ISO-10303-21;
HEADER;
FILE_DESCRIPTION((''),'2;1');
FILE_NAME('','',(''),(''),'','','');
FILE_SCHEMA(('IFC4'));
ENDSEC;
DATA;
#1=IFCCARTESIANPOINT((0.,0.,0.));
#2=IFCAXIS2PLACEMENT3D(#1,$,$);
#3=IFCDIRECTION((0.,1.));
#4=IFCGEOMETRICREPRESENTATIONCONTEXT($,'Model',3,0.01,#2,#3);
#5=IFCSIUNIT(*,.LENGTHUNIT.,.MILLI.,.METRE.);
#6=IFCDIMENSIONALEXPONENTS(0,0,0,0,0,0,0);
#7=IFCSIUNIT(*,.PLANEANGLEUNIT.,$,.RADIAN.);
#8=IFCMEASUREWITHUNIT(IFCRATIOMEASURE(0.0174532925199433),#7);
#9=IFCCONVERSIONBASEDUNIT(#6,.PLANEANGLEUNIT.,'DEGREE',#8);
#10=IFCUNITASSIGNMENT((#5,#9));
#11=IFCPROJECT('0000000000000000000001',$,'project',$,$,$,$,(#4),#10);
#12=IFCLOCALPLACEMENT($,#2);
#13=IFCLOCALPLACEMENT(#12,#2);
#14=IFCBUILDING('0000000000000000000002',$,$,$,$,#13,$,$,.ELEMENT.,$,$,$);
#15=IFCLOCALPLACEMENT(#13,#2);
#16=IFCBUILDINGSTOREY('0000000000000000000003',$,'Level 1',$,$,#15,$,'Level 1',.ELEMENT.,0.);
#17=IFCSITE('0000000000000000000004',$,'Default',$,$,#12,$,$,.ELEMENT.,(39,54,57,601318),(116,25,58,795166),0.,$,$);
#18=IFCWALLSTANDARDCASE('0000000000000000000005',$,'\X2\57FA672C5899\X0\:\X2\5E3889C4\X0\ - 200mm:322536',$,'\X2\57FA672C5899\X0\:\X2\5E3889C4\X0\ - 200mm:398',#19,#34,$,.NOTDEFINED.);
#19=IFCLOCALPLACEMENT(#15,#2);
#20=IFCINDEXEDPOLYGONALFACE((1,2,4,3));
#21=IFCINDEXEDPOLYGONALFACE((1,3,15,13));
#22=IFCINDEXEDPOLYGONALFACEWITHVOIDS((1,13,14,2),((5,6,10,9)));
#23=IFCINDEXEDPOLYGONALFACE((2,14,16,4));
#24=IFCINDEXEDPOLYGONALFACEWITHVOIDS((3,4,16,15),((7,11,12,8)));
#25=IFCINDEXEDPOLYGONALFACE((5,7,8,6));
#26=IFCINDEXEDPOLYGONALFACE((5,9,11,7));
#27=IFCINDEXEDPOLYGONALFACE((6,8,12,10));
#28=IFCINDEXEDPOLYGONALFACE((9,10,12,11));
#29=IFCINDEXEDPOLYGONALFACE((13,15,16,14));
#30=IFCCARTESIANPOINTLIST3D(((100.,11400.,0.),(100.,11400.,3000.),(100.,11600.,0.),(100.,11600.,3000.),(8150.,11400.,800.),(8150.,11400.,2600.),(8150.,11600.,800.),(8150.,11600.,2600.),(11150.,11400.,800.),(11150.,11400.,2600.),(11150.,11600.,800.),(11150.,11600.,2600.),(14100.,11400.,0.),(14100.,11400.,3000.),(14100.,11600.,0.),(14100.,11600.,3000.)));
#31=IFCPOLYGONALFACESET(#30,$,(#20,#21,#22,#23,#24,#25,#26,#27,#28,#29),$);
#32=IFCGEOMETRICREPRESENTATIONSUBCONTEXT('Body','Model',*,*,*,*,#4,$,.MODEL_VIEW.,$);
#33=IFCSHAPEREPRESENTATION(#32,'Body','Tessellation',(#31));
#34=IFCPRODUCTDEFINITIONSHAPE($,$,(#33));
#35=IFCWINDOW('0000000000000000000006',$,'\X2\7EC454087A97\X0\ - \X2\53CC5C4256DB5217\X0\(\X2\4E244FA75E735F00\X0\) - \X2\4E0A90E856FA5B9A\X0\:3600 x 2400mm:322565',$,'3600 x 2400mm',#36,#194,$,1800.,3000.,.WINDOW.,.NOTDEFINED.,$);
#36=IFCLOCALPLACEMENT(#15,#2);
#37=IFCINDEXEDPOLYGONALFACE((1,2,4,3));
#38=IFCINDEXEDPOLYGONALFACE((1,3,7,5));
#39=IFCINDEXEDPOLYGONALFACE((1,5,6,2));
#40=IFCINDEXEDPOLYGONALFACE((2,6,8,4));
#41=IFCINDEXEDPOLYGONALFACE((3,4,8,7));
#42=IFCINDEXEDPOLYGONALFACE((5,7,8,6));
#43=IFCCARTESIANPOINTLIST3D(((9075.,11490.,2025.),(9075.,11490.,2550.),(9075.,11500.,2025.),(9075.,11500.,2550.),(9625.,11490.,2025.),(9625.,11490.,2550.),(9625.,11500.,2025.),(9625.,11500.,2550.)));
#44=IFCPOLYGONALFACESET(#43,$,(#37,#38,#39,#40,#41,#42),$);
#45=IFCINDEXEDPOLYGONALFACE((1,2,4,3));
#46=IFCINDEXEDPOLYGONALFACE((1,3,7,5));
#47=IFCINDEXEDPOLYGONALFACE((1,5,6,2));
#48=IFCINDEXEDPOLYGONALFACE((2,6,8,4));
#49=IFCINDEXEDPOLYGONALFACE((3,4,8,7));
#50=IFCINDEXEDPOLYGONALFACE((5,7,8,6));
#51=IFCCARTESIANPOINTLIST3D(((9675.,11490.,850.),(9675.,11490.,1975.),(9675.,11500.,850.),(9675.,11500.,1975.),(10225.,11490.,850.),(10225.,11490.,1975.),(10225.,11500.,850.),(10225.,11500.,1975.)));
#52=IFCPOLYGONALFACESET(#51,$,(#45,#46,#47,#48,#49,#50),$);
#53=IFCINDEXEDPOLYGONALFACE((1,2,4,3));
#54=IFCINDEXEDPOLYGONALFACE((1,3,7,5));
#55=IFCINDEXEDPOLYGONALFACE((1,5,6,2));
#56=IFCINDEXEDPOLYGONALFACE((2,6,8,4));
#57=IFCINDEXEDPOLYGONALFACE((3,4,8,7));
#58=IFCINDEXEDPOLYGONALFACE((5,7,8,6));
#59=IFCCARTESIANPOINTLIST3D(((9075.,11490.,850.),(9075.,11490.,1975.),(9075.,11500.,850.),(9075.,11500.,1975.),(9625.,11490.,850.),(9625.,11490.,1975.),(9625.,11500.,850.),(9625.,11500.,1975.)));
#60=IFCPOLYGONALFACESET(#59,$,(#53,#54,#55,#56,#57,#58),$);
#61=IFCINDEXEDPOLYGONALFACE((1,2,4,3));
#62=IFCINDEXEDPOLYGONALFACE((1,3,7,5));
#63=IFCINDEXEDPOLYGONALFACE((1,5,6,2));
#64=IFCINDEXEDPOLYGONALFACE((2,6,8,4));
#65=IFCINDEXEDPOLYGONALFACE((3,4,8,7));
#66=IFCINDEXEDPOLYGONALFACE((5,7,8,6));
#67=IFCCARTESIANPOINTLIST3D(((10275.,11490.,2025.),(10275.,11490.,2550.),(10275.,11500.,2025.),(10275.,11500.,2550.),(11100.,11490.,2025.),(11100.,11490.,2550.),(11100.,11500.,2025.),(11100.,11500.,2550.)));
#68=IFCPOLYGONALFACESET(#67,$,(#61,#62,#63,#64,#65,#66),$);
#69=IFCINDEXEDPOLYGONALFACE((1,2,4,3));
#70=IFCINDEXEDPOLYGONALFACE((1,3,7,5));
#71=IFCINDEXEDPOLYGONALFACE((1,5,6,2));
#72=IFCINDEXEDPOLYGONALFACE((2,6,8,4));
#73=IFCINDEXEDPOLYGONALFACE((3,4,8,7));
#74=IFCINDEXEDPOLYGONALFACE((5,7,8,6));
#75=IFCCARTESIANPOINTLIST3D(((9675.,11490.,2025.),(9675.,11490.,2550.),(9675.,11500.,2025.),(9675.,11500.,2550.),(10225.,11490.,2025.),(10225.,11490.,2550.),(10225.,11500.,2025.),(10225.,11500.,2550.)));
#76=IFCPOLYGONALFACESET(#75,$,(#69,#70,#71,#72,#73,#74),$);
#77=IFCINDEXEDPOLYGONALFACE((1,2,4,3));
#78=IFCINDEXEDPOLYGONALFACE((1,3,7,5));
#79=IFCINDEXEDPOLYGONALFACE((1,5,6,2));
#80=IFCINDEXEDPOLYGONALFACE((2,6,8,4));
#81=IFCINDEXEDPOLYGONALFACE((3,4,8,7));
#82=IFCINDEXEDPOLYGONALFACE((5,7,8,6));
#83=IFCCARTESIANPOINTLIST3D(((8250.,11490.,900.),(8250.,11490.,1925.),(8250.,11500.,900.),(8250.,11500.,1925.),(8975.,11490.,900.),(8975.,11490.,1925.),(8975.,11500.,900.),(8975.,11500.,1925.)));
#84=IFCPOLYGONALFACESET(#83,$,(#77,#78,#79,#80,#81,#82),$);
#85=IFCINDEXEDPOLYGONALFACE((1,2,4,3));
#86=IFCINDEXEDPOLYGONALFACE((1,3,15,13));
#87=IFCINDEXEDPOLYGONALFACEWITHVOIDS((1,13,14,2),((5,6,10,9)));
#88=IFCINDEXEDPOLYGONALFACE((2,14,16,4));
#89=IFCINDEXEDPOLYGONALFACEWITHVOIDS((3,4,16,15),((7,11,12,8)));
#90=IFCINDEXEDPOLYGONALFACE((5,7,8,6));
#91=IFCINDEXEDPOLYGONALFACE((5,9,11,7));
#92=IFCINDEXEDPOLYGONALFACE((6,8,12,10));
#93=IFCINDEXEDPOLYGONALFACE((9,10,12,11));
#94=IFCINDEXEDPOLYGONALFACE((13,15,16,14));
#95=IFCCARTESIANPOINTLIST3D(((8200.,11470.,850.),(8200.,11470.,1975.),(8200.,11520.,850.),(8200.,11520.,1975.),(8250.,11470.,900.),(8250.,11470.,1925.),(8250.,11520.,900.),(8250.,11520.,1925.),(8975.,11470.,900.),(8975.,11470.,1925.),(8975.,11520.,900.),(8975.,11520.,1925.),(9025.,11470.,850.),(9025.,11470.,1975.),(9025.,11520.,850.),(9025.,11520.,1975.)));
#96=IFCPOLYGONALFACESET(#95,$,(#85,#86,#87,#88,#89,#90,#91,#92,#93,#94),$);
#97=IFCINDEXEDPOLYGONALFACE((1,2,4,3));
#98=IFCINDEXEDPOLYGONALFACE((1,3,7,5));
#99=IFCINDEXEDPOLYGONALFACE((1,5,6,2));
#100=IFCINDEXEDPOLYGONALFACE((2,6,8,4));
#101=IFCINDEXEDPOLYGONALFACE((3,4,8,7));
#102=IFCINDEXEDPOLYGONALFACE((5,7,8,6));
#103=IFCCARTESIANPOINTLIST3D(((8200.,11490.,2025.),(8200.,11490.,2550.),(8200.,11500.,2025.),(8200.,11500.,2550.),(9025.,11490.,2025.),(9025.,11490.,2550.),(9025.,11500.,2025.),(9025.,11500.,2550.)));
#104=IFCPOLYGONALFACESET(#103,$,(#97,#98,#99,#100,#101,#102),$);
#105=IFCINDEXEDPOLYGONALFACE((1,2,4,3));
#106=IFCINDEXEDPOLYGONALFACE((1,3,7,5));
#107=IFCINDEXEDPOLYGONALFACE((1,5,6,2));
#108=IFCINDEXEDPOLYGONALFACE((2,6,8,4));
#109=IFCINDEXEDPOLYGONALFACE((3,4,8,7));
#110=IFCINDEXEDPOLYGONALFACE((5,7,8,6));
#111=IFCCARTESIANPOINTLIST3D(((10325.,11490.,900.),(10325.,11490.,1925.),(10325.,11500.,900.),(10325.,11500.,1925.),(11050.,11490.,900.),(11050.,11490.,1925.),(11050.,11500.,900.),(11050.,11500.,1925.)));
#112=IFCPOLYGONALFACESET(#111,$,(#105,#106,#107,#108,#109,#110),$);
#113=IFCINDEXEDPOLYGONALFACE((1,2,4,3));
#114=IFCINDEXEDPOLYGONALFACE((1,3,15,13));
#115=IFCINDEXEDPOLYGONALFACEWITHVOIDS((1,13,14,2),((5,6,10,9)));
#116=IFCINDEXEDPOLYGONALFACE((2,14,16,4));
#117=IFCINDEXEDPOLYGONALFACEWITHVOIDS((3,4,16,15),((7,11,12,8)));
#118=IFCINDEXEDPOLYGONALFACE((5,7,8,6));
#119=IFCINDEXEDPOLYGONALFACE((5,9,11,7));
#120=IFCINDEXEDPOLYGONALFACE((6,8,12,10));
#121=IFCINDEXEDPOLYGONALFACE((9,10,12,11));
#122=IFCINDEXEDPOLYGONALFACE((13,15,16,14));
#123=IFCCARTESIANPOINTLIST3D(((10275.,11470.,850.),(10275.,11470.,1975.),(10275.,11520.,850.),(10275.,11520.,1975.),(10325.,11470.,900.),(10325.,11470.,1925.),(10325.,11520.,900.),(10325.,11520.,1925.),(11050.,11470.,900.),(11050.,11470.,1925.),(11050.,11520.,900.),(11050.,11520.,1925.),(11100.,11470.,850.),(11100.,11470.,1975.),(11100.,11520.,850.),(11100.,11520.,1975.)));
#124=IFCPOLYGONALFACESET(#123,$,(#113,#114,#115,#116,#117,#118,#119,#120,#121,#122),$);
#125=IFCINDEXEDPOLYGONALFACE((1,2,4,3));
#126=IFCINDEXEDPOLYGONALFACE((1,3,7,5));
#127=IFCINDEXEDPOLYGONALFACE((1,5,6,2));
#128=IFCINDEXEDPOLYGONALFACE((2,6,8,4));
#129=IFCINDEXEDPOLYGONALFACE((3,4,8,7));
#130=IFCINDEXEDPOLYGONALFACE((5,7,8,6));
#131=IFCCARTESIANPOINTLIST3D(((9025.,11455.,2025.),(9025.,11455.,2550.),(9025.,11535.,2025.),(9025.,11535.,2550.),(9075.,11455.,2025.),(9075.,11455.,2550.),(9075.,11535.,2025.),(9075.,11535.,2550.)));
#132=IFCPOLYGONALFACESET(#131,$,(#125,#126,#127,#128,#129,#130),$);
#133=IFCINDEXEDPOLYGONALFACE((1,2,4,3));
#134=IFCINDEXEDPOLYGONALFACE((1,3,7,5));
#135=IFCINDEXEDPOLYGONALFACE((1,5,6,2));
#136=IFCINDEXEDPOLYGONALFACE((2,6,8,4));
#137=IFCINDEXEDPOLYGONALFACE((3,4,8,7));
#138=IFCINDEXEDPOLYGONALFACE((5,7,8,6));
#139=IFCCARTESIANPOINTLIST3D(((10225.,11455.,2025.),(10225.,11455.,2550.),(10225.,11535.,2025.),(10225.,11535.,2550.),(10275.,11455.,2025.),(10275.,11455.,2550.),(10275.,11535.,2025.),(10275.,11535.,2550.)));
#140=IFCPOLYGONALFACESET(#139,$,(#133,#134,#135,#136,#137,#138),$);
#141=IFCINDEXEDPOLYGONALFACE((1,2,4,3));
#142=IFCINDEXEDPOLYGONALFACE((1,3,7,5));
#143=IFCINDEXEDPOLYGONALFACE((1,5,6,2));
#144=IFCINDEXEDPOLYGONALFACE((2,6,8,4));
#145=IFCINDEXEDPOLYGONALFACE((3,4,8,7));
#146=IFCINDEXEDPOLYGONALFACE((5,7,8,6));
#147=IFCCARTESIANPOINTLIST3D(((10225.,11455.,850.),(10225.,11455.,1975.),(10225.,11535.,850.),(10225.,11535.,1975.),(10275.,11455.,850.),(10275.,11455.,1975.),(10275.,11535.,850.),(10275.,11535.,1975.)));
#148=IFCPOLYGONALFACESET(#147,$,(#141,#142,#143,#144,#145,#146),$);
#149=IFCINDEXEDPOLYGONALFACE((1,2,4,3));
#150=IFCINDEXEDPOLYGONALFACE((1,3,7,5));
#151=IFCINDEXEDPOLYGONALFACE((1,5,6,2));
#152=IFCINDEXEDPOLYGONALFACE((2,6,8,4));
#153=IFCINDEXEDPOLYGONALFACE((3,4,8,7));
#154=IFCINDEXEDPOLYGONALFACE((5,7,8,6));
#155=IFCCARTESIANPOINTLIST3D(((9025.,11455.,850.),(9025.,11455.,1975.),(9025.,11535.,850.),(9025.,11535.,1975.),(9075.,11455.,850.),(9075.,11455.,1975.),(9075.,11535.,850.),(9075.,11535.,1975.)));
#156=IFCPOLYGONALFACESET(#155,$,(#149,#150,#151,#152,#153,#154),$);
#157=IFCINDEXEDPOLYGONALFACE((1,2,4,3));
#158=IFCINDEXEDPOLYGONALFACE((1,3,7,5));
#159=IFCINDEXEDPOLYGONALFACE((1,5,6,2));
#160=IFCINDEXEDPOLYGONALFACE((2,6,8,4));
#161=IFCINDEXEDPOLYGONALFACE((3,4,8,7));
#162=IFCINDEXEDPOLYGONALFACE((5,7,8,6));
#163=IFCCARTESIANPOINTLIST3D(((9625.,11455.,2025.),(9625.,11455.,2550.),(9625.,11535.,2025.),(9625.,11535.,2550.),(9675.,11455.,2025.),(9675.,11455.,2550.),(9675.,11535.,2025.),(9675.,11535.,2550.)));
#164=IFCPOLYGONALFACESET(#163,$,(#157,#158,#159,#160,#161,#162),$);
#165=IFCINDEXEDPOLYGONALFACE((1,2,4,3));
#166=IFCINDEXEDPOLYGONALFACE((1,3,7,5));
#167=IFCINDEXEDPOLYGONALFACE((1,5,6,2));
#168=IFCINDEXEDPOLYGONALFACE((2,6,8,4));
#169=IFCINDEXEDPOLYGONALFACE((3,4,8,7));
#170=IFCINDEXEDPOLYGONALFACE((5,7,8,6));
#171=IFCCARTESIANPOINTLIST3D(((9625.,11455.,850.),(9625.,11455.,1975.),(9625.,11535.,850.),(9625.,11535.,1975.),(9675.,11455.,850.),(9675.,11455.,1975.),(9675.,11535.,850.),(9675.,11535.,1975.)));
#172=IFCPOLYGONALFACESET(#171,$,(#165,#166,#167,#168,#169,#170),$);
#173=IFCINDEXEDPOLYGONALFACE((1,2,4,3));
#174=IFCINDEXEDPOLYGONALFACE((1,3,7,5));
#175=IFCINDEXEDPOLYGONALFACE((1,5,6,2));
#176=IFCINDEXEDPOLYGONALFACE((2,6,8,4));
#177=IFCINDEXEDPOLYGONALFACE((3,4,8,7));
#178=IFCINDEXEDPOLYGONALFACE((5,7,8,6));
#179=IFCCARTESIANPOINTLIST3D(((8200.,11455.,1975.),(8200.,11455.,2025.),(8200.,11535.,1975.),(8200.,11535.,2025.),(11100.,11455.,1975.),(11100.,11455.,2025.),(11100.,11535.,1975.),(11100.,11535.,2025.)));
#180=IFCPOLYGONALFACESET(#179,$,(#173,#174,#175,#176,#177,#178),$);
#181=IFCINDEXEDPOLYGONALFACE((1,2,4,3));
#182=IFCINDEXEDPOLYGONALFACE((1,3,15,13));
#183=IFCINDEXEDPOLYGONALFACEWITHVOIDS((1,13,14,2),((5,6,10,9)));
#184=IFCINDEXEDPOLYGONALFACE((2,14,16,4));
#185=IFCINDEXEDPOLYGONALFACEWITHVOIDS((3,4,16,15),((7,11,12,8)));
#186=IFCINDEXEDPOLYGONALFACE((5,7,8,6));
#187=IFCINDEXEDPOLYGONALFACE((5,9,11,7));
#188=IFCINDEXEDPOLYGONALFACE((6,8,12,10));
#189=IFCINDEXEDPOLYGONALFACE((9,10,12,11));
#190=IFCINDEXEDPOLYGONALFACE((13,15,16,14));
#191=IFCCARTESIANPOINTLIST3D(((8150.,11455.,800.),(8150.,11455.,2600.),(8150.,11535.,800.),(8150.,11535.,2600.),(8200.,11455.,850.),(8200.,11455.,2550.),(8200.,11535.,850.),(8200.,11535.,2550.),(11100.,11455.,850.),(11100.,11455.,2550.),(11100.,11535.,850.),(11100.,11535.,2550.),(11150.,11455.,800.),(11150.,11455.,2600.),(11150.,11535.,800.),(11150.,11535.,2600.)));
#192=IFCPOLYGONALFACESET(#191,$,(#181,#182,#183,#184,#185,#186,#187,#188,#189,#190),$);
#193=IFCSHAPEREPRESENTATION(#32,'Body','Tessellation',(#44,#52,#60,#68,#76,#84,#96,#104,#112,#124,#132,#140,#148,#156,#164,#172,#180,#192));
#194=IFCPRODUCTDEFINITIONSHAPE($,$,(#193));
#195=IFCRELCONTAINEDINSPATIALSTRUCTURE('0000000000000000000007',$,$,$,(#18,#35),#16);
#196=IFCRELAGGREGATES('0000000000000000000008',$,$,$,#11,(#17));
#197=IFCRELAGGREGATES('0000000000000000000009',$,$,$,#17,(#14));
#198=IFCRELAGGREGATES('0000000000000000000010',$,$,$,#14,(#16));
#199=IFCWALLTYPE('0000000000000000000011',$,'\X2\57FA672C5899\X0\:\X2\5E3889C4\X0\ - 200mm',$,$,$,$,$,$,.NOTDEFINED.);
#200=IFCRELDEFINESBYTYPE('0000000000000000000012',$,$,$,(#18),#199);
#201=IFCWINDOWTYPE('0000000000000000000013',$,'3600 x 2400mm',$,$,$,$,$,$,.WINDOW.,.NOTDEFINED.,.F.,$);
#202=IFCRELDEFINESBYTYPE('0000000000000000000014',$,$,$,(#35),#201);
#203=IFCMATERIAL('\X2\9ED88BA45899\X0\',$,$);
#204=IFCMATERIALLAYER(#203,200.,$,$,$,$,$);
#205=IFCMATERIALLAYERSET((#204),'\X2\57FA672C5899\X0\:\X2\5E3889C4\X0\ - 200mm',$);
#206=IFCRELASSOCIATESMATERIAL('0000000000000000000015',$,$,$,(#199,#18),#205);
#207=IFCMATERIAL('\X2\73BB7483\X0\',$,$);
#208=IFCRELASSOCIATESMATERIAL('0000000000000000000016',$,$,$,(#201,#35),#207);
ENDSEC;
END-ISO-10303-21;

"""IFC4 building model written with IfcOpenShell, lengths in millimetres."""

from ifc_helpers import new_model, entity, si_unit, converted_unit, direction, frame, frame_2d, origin, origin_2d_with_axis, place, context, subcontext, project, spatial, polyline, rectangle, outline, extrude, source, transform, mapped, material, layer, layer_set, layer_usage, type_object, type_shapes, element, fill, save


model = new_model("IFC4")

# Units and contexts
model_context = context("Model", 3, precision=0.01, world=origin(), true_north=direction((0.0, 1.0)))
body_context = subcontext(model_context, "Body", "Model", "MODEL_VIEW")
ifc_project = project(units=[si_unit("LENGTHUNIT", "METRE", prefix="MILLI"), converted_unit("PLANEANGLEUNIT", "DEGREE", entity("IfcRatioMeasure", 0.0174532925199433), si_unit("PLANEANGLEUNIT", "RADIAN"), dimensions=[0, 0, 0, 0, 0, 0, 0])], contexts=[model_context])

# Site, building, storey
site_placement = place(None, origin())
site = spatial("IfcSite", under=ifc_project, at=site_placement, Name="Default", CompositionType="ELEMENT", RefLatitude=(39, 54, 57, 601318), RefLongitude=(116, 25, 58, 795166), RefElevation=0.0)
building_placement = place(site_placement, origin())
building = spatial("IfcBuilding", under=site, at=building_placement, CompositionType="ELEMENT")
storey_placement = place(building_placement, origin())
storey = spatial("IfcBuildingStorey", under=building, at=storey_placement, Name="Level 1", LongName="Level 1", CompositionType="ELEMENT", Elevation=0.0)

# Shared definitions
ifc_material_1 = material(Name="默认墙")
ifc_layer_1 = layer(ifc_material_1, 200.0)
ifc_layer_set_1 = layer_set([ifc_layer_1], Name="基本墙:常规 - 200mm")
wall_type = type_object("IfcWallType", Name="基本墙:常规 - 200mm", PredefinedType="NOTDEFINED", material=ifc_layer_set_1)
ifc_material_2 = material(Name="玻璃")
window_type_1 = type_object("IfcWindowType", Name="3600 x 2400mm", ParameterTakesPrecedence=False, PartitioningType="NOTDEFINED", PredefinedType="WINDOW", material=ifc_material_2)
shared_shape_1 = source(origin(), body_context, "Body", "SweptSolid", [
    extrude(rectangle(XDim=10.0, YDim=550.0, at=origin_2d_with_axis()), frame((1200.0, 95.0, 1225.0), z_axis=(0.0, 0.0, 1.0), x_axis=(0.0, 1.0, 0.0)), (0.0, 0.0, 1.0), 525.0),
    extrude(rectangle(XDim=10.0, YDim=550.0, at=origin_2d_with_axis()), frame((1800.0, 95.0, 50.0), z_axis=(0.0, 0.0, 1.0), x_axis=(0.0, 1.0, 0.0)), (0.0, 0.0, 1.0), 1125.0),
    extrude(rectangle(XDim=10.0, YDim=550.0, at=origin_2d_with_axis()), frame((1200.0, 95.0, 50.0), z_axis=(0.0, 0.0, 1.0), x_axis=(0.0, 1.0, 0.0)), (0.0, 0.0, 1.0), 1125.0),
    extrude(rectangle(XDim=10.0, YDim=825.0, at=frame_2d((0.0, 0.0), x_axis=(1.0, 0.0))), frame((2537.5, 95.0, 1225.0), z_axis=(0.0, 0.0, 1.0), x_axis=(0.0, 1.0, 0.0)), (0.0, 0.0, 1.0), 525.0),
    extrude(rectangle(XDim=10.0, YDim=550.0, at=frame_2d((0.0, 0.0), x_axis=(1.0, 0.0))), frame((1800.0, 95.0, 1225.0), z_axis=(0.0, 0.0, 1.0), x_axis=(0.0, 1.0, 0.0)), (0.0, 0.0, 1.0), 525.0),
    extrude(rectangle(XDim=10.0, YDim=725.0, at=frame_2d((0.0, 0.0), x_axis=(1.0, 0.0))), frame((462.5, 95.0, 100.0), z_axis=(0.0, 0.0, 1.0), x_axis=(0.0, 1.0, 0.0)), (0.0, 0.0, 1.0), 1025.0),
    extrude(outline(polyline([(-562.5, -412.5), (562.5, -412.5), (562.5, 412.5), (-562.5, 412.5), (-562.5, -412.5)]), holes=[polyline([(512.5, -362.5), (-512.5, -362.5), (-512.5, 362.5), (512.5, 362.5), (512.5, -362.5)])]), frame((462.5, 70.0, 612.5), z_axis=(0.0, 1.0, 0.0), x_axis=(0.0, 0.0, -1.0)), (0.0, 0.0, 1.0), 50.0),
    extrude(rectangle(XDim=10.0, YDim=825.0, at=origin_2d_with_axis()), frame((462.5, 95.0, 1225.0), z_axis=(0.0, 0.0, 1.0), x_axis=(0.0, 1.0, 0.0)), (0.0, 0.0, 1.0), 525.0),
    extrude(rectangle(XDim=10.0, YDim=725.0, at=frame_2d((0.0, 0.0), x_axis=(1.0, 0.0))), frame((2537.5, 95.0, 100.0), z_axis=(0.0, 0.0, 1.0), x_axis=(0.0, 1.0, 0.0)), (0.0, 0.0, 1.0), 1025.0),
    extrude(outline(polyline([(-562.5, -412.5), (562.5, -412.5), (562.5, 412.5), (-562.5, 412.5), (-562.5, -412.5)]), holes=[polyline([(512.5, -362.5), (-512.5, -362.5), (-512.5, 362.5), (512.5, 362.5), (512.5, -362.5)])]), frame((2537.5, 70.0, 612.5), z_axis=(0.0, 1.0, 0.0), x_axis=(0.0, 0.0, -1.0)), (0.0, 0.0, 1.0), 50.0),
    extrude(rectangle(XDim=80.0, YDim=50.0, at=origin_2d_with_axis()), frame((900.0, 95.0, 1225.0), z_axis=(0.0, 0.0, 1.0), x_axis=(0.0, -1.0, 0.0)), (0.0, 0.0, 1.0), 525.0),
    extrude(rectangle(XDim=80.0, YDim=50.0, at=frame_2d((0.0, 0.0), x_axis=(1.0, 0.0))), frame((2100.0, 95.0, 1225.0), z_axis=(0.0, 0.0, 1.0), x_axis=(0.0, -1.0, 0.0)), (0.0, 0.0, 1.0), 525.0),
    extrude(rectangle(XDim=80.0, YDim=50.0, at=origin_2d_with_axis()), frame((2100.0, 95.0, 50.0), z_axis=(0.0, 0.0, 1.0), x_axis=(0.0, -1.0, 0.0)), (0.0, 0.0, 1.0), 1125.0),
    extrude(rectangle(XDim=80.0, YDim=50.0, at=origin_2d_with_axis()), frame((900.0, 95.0, 50.0), z_axis=(0.0, 0.0, 1.0), x_axis=(0.0, -1.0, 0.0)), (0.0, 0.0, 1.0), 1125.0),
    extrude(rectangle(XDim=80.0, YDim=50.0, at=frame_2d((0.0, 0.0), x_axis=(1.0, 0.0))), frame((1500.0, 95.0, 1225.0), z_axis=(0.0, 0.0, 1.0), x_axis=(0.0, -1.0, 0.0)), (0.0, 0.0, 1.0), 525.0),
    extrude(rectangle(XDim=80.0, YDim=50.0, at=origin_2d_with_axis()), frame((1500.0, 95.0, 50.0), z_axis=(0.0, 0.0, 1.0), x_axis=(0.0, -1.0, 0.0)), (0.0, 0.0, 1.0), 1125.0),
    extrude(rectangle(XDim=80.0, YDim=2900.0, at=frame_2d((0.0, 0.0), x_axis=(1.0, 0.0))), frame((1500.0, 95.0, 1175.0), z_axis=(0.0, 0.0, 1.0), x_axis=(0.0, -1.0, 0.0)), (0.0, 0.0, 1.0), 50.0),
    extrude(outline(polyline([(-1500.0, -900.0), (1500.0, -900.0), (1500.0, 900.0), (-1500.0, 900.0), (-1500.0, -900.0)]), holes=[polyline([(1450.0, -850.0), (-1450.0, -850.0), (-1450.0, 850.0), (1450.0, 850.0), (1450.0, -850.0)])]), frame((1500.0, 55.0, 900.0), z_axis=(0.0, 1.0, 0.0), x_axis=(1.0, 0.0, 0.0)), (0.0, 0.0, 1.0), 80.0),
])
type_shapes(window_type_1, [shared_shape_1])

# Wall, opening, window
ifc_layer_usage_1 = layer_usage(ifc_layer_set_1, "AXIS2", "NEGATIVE", 100.0)
wall_1_placement = place(storey_placement, frame((100.0, 11500.0, 0.0)))
wall_1 = element("IfcWallStandardCase", 1, at=wall_1_placement, inside=storey, type_object=wall_type, material=ifc_layer_usage_1, Name="基本墙:常规 - 200mm:322536", ObjectType="基本墙:常规 - 200mm:398", PredefinedType="NOTDEFINED", context=body_context, shape_type="SweptSolid", body=[
    extrude(rectangle(XDim=14000.0, YDim=200.0, at=frame_2d((7000.0, 0.0), x_axis=(-1.0, 0.0))), origin(), (0.0, 0.0, 1.0), 3000.0),
])
opening_1_placement = place(wall_1_placement, frame((8050.0, -100.0, 800.0)))
opening_1 = element("IfcOpeningElement", 2, at=opening_1_placement, cuts=wall_1, ObjectType="Opening", PredefinedType="OPENING", context=body_context, shape_type="SweptSolid", body=[
    extrude(rectangle(XDim=1800.0, YDim=3000.0, at=frame_2d((900.0, 1500.0), x_axis=(1.0, 0.0))), frame((0.0, 0.0, 0.0), z_axis=(0.0, 1.0, 0.0), x_axis=(0.0, 0.0, 1.0)), (0.0, 0.0, 1.0), 200.0),
])
window_1_placement = place(opening_1_placement, origin())
window_1 = element("IfcWindow", 3, at=window_1_placement, inside=storey, type_object=window_type_1, material=ifc_material_2, Name="组合窗 - 双层四列(两侧平开) - 上部固定:3600 x 2400mm:322565", ObjectType="3600 x 2400mm", OverallHeight=1800.0, OverallWidth=3000.0, PartitioningType="NOTDEFINED", PredefinedType="WINDOW", context=body_context, shape_type="MappedRepresentation", body=[
    mapped(shared_shape_1, transform((0.0, 0.0, 0.0), scale=1.0)),
])
fill(opening_1, window_1)

save(model, "model.ifc")
